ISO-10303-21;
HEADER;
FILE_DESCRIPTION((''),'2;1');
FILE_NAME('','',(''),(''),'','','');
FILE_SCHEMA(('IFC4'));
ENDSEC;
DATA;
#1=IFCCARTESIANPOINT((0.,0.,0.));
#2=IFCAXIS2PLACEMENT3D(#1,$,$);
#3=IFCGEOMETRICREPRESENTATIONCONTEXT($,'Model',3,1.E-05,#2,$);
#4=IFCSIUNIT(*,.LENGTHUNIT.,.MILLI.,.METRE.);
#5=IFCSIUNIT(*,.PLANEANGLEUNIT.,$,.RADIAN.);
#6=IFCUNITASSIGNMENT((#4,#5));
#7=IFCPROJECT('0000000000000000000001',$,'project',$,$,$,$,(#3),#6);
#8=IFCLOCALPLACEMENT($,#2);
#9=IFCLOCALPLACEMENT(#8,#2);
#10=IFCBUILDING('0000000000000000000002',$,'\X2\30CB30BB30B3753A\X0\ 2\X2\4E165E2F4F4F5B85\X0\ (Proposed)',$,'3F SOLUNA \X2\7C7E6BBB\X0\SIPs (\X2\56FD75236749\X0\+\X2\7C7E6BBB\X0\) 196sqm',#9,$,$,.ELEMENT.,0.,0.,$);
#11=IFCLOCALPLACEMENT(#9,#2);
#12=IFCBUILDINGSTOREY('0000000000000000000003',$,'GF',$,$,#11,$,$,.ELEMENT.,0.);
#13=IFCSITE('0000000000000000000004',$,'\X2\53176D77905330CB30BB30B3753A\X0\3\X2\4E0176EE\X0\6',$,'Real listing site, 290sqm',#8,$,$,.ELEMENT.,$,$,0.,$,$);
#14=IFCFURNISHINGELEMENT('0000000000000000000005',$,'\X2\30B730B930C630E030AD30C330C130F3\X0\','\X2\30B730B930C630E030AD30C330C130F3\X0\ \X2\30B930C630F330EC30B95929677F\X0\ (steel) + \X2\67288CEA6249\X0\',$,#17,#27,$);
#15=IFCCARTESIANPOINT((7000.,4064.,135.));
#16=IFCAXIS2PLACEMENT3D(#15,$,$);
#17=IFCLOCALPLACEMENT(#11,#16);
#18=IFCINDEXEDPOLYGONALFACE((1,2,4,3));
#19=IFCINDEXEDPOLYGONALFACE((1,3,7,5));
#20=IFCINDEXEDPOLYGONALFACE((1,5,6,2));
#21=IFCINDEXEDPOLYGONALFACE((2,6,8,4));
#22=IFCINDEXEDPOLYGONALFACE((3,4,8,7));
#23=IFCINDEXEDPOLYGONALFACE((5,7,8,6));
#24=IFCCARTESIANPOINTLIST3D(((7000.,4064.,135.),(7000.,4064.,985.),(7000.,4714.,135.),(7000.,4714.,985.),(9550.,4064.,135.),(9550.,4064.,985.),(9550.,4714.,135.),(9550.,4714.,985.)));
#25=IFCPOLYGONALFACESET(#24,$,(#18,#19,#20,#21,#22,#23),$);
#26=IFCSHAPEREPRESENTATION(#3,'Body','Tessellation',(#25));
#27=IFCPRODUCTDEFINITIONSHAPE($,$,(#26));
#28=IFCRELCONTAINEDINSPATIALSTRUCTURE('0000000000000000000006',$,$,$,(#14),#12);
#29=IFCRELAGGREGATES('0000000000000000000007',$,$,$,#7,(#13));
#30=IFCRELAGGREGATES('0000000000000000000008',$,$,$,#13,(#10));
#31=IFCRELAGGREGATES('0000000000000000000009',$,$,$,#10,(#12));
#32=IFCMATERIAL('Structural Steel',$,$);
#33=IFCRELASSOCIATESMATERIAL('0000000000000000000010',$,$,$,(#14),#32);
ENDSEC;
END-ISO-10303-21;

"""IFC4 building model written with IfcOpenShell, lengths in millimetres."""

from ifc_helpers import new_model, si_unit, frame, frame_2d, origin, place, context, project, spatial, rectangle, extrude, material, element, save


model = new_model("IFC4")

# Units and contexts
model_context = context("Model", 3, precision=1e-05, world=origin())
ifc_project = project(units=[si_unit("LENGTHUNIT", "METRE", prefix="MILLI"), si_unit("PLANEANGLEUNIT", "RADIAN")], contexts=[model_context])

# Site, building, storey
site_placement = place(None, origin())
site = spatial("IfcSite", under=ifc_project, at=site_placement, Name="北海道ニセコ町3丁目6", ObjectType="Real listing site, 290sqm", CompositionType="ELEMENT", RefElevation=0.0)
building_placement = place(site_placement, origin())
building = spatial("IfcBuilding", under=site, at=building_placement, Name="ニセコ町 2世帯住宅 (Proposed)", ObjectType="3F SOLUNA 籾殻SIPs (国産杉+籾殻) 196sqm", CompositionType="ELEMENT", ElevationOfRefHeight=0.0, ElevationOfTerrain=0.0)
storey_placement = place(building_placement, origin())
storey = spatial("IfcBuildingStorey", under=building, at=storey_placement, Name="GF", CompositionType="ELEMENT", Elevation=0.0)

# Furnishing element
ifc_material_1 = material(Name="Structural Steel")
furnishing_1_placement = place(storey_placement, frame((7000.0, 4064.0, 135.0)))
element("IfcFurnishingElement", 1, at=furnishing_1_placement, inside=storey, material=ifc_material_1, Name="システムキッチン", Description="システムキッチン ステンレス天板 (steel) + 木質扉", context=model_context, shape_type="SweptSolid", body=[
    extrude(rectangle(XDim=2550.0, YDim=650.0, at=frame_2d((1275.0, 325.0))), frame((7000.0, 4064.0, 135.0)), (0.0, 0.0, 1.0), 850.0),
])

save(model, "model.ifc")
